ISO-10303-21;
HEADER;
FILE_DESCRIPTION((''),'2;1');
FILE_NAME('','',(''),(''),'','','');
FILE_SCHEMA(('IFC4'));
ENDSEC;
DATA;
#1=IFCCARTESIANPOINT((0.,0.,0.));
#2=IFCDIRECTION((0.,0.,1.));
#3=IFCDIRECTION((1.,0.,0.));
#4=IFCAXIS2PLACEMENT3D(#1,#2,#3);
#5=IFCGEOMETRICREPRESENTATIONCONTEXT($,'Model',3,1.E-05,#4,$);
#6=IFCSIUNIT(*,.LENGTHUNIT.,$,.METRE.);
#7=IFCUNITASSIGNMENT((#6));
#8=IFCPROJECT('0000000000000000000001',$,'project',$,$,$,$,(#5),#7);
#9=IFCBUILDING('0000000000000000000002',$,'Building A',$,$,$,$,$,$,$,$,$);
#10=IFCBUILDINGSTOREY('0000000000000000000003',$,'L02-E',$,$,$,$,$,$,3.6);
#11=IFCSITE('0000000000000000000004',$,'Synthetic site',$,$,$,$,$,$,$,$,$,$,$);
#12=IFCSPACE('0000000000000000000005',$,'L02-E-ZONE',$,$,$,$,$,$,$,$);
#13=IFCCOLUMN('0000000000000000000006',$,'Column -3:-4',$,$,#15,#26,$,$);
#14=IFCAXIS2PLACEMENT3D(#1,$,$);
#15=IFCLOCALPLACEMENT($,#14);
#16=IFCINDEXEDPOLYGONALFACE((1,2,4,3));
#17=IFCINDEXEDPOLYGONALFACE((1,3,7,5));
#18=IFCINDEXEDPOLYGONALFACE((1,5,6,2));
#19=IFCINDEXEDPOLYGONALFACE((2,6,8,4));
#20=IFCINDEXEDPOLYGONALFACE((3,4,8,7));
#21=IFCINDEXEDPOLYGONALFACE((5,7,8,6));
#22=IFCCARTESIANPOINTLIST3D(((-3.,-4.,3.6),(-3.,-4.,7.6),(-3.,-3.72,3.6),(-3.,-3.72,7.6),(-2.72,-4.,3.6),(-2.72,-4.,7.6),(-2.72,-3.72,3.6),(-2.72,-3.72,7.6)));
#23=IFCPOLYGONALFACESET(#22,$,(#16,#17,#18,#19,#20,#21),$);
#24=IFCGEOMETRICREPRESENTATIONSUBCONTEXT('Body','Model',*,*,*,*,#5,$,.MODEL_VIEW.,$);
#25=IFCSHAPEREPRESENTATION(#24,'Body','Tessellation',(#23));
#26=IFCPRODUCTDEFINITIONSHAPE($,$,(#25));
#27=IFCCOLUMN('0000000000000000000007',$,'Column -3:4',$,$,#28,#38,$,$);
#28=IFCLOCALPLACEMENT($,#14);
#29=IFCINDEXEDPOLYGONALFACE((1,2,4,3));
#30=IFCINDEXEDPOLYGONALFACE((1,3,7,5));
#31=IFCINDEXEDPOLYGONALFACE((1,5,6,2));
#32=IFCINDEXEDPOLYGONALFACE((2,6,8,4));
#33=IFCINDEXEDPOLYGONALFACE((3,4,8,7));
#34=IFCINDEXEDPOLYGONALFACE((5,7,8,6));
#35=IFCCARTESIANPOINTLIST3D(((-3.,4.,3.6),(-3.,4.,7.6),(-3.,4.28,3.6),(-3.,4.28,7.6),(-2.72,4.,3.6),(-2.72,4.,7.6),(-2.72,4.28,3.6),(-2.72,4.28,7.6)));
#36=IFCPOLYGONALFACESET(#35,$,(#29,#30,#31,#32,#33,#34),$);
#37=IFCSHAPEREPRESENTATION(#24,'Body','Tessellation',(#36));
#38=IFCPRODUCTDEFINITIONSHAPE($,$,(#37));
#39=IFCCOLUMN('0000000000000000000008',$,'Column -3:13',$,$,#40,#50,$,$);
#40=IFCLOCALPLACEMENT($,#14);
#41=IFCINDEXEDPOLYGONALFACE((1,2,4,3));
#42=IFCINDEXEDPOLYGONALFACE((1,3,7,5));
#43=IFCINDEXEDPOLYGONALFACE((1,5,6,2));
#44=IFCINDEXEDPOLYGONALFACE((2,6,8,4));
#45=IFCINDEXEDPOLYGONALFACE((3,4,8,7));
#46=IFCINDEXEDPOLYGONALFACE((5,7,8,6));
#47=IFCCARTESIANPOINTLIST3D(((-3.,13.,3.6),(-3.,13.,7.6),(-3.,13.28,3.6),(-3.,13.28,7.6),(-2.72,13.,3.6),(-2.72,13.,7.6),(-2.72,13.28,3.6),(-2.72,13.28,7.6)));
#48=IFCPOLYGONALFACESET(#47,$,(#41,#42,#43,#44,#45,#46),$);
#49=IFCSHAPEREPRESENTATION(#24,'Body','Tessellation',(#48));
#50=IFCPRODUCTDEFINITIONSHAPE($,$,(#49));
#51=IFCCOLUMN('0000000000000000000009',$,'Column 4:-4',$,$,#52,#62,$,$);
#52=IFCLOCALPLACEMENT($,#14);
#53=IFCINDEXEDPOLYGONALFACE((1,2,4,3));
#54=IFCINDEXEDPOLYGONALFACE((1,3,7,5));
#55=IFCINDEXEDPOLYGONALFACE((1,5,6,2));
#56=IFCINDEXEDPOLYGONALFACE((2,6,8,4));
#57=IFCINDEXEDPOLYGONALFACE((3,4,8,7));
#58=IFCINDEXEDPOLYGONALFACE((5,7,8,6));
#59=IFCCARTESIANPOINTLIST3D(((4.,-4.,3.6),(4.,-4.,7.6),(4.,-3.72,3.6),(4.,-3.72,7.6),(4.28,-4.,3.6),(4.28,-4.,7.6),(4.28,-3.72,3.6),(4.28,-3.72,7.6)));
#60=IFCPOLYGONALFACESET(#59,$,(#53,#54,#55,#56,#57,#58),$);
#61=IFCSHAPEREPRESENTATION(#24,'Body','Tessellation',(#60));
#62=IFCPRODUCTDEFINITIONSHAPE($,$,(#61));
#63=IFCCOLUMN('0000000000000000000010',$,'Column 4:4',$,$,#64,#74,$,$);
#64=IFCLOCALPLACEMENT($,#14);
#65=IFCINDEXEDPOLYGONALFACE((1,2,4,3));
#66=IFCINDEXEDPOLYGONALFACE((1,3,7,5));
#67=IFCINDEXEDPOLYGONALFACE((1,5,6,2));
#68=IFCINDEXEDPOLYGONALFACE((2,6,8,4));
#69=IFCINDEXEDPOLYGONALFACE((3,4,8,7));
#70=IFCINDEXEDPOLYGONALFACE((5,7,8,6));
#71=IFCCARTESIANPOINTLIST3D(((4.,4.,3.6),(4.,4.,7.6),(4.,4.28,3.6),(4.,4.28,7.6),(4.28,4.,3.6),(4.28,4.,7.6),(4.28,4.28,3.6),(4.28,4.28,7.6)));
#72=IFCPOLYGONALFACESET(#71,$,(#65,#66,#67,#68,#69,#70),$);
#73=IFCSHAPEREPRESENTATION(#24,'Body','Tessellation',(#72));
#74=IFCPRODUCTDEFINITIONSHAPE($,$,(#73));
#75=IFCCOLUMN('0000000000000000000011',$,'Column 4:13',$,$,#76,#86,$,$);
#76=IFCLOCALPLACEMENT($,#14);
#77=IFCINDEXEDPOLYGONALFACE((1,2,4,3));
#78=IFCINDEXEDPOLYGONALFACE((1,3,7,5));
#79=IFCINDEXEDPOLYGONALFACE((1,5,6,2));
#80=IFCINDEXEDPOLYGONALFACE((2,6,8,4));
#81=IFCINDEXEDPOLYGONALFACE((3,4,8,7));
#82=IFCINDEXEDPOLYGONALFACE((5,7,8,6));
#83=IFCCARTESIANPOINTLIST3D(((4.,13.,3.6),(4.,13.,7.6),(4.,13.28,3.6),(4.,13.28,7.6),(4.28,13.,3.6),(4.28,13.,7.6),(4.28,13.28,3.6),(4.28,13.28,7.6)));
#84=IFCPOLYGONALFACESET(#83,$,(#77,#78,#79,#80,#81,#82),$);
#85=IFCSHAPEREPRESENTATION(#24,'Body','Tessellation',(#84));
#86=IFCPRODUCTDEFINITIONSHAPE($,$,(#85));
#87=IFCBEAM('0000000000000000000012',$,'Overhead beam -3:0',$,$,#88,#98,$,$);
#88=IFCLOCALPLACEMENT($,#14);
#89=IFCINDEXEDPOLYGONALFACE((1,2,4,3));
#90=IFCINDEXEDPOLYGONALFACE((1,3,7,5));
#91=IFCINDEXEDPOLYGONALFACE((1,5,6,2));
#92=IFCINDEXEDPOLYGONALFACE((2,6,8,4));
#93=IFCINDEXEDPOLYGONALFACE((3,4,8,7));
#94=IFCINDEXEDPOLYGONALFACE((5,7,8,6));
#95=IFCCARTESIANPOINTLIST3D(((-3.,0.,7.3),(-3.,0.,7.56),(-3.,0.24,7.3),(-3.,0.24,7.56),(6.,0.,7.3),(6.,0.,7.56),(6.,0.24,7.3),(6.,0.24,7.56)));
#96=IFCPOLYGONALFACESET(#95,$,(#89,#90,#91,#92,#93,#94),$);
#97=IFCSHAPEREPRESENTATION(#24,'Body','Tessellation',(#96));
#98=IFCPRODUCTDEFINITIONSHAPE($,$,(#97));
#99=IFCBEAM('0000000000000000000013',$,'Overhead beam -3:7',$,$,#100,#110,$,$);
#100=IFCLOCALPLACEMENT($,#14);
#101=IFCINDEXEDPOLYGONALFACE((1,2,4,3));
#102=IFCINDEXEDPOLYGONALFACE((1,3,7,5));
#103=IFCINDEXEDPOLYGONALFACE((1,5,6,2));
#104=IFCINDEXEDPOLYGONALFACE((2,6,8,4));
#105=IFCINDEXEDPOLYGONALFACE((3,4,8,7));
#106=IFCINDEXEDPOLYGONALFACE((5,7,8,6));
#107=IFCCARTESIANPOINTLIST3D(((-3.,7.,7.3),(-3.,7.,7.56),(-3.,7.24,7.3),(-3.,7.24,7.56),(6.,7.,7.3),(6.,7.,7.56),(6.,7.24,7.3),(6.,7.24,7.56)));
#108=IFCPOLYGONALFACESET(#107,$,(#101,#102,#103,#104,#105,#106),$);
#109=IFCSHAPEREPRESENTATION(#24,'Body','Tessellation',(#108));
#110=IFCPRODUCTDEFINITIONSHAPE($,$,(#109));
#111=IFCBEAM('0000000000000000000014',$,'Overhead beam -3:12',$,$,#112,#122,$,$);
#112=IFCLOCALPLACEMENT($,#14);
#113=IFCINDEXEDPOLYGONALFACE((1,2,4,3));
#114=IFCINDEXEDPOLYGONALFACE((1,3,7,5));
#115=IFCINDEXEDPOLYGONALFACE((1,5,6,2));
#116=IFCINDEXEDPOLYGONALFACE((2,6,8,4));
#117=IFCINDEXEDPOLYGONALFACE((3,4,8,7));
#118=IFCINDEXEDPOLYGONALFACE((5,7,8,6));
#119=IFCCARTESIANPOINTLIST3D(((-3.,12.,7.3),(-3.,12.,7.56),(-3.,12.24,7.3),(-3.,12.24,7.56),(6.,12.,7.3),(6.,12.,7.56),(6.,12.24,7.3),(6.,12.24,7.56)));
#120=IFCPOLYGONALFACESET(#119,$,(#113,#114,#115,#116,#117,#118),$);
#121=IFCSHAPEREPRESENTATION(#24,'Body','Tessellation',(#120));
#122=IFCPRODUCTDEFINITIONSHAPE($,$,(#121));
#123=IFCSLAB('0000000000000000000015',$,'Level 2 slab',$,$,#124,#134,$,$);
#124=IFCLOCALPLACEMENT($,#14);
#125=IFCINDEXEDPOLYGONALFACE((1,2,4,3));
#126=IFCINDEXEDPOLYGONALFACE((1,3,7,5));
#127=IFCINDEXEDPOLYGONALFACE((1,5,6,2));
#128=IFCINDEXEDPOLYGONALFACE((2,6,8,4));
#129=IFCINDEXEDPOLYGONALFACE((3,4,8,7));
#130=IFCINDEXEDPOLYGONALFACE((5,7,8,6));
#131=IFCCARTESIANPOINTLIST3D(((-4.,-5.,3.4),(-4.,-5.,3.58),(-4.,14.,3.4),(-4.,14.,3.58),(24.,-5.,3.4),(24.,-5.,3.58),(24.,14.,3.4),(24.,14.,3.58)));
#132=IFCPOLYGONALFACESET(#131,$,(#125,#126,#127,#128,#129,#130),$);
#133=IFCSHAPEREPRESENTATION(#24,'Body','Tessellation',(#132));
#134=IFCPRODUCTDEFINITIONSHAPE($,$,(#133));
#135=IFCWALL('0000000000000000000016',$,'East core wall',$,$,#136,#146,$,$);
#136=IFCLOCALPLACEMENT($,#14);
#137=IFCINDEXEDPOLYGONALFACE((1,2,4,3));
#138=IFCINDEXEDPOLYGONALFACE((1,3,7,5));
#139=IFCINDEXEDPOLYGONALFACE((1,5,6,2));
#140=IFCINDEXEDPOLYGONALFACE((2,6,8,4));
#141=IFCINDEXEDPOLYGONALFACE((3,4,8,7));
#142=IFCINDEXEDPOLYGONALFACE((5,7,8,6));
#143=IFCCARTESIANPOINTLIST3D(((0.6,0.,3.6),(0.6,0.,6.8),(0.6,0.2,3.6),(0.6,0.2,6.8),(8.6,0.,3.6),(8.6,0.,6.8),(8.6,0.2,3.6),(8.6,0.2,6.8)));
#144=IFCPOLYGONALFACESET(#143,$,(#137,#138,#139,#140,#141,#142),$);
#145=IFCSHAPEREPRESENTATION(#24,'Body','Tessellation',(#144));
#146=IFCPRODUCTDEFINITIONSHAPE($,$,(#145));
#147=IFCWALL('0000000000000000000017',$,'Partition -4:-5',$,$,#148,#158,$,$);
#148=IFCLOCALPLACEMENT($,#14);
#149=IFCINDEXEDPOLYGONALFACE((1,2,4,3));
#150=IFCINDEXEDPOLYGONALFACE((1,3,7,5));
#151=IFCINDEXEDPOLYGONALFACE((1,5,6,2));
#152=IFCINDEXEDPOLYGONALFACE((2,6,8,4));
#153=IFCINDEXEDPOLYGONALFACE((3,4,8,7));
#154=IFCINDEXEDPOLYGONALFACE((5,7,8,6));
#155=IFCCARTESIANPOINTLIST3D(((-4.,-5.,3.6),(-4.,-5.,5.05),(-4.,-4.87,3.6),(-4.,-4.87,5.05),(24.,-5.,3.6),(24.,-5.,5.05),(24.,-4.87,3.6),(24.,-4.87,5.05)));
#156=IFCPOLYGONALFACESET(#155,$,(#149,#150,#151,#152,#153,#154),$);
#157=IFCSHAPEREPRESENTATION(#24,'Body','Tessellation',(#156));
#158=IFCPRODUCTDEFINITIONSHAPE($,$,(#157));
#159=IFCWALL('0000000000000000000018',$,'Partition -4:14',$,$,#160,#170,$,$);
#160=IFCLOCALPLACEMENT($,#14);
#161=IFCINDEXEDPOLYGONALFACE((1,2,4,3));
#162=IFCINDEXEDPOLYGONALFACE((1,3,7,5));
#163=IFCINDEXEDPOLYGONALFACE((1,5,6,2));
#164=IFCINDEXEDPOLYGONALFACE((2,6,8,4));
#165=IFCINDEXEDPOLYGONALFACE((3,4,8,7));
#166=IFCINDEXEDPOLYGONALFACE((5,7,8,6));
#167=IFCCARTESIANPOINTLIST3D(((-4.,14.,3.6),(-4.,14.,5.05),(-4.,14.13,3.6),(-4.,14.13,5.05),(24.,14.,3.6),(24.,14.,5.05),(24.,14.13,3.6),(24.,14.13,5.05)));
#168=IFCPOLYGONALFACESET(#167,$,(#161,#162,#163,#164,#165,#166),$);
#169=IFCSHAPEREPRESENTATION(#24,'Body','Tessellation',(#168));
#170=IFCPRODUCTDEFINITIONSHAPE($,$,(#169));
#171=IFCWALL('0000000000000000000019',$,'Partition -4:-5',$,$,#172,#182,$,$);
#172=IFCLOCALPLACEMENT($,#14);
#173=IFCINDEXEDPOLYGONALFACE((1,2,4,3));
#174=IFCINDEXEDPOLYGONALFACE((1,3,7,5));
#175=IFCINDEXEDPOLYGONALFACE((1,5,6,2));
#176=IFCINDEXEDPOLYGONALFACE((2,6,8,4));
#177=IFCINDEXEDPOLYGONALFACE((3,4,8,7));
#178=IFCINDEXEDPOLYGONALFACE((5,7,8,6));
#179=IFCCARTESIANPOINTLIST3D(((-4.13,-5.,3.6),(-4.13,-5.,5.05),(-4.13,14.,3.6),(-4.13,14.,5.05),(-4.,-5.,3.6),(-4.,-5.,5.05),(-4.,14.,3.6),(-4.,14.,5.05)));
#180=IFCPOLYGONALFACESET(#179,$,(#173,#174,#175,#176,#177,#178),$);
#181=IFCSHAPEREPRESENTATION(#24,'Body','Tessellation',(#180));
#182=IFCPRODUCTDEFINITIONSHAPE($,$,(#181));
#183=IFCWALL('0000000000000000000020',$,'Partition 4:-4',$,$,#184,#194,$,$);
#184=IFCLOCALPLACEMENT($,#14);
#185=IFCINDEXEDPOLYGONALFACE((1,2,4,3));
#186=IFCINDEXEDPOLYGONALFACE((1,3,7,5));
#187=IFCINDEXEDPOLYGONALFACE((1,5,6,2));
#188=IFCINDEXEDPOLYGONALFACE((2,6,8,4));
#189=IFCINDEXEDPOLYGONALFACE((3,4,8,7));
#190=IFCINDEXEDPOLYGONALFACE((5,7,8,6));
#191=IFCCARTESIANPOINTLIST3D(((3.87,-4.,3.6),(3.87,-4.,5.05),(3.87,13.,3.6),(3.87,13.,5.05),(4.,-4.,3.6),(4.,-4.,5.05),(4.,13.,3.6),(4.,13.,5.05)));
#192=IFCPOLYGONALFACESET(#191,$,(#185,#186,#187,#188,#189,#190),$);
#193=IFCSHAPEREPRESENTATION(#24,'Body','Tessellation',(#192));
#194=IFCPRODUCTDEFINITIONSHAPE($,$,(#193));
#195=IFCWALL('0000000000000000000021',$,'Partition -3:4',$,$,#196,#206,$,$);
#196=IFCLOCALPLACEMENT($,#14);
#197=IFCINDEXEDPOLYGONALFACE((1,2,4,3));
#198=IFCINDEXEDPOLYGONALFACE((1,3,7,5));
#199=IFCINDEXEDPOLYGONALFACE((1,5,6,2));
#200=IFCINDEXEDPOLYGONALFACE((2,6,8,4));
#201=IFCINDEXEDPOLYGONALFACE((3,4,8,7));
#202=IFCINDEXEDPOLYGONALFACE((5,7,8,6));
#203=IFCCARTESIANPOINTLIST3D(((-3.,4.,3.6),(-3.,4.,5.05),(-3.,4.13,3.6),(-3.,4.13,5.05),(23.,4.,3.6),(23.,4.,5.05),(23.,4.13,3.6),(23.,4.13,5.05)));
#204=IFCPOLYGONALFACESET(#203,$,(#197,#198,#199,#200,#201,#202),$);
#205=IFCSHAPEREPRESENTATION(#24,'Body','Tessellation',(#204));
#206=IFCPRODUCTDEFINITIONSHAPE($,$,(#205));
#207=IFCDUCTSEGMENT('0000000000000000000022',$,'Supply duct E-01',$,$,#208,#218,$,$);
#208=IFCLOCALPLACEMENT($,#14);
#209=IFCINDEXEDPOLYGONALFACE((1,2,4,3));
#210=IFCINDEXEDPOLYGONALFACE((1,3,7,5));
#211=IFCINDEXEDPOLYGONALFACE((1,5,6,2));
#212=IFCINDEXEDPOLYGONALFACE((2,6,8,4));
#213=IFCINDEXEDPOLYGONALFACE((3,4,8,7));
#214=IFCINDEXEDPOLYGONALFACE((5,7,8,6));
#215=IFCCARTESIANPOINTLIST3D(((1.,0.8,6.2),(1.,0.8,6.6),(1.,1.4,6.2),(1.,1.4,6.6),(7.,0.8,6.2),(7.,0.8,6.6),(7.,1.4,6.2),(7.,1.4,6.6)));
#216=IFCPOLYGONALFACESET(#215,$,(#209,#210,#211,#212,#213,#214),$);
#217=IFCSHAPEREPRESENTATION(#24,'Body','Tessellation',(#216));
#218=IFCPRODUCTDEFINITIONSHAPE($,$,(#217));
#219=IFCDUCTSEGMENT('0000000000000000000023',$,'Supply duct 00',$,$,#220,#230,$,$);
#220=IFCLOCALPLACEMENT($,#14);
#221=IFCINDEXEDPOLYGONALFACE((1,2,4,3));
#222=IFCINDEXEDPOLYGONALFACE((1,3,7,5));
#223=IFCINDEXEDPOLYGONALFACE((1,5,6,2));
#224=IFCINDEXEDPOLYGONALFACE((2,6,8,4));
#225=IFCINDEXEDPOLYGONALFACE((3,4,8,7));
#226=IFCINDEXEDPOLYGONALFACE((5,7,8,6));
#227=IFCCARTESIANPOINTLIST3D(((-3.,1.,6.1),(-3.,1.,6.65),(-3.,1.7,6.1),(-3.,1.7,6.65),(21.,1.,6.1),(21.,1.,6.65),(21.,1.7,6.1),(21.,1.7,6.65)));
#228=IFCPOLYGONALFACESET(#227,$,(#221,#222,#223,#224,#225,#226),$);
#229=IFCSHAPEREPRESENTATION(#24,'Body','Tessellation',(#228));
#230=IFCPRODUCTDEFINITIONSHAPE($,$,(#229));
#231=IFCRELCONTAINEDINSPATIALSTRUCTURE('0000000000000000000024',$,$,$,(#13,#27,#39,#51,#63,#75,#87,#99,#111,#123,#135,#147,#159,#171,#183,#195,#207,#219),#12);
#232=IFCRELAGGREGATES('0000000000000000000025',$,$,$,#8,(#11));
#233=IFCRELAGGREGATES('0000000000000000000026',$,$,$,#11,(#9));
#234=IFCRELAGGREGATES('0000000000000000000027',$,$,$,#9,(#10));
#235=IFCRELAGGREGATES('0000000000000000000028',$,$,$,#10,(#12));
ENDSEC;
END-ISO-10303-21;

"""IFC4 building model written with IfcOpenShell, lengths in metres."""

from ifc_helpers import new_model, si_unit, frame, origin_with_axes, place, context, subcontext, project, spatial, indexed_curve, outline, extrude, element, save


model = new_model("IFC4")

# Units and contexts
model_context = context("Model", 3, precision=1e-05, world=origin_with_axes())
body_context = subcontext(model_context, "Body", "Model", "MODEL_VIEW")
ifc_project = project(units=[si_unit("LENGTHUNIT", "METRE")], contexts=[model_context])

# Site, building, storey, space
site = spatial("IfcSite", under=ifc_project, Name="Synthetic site")
building = spatial("IfcBuilding", under=site, Name="Building A")
storey = spatial("IfcBuildingStorey", under=building, Name="L02-E", Elevation=3.6)
space = spatial("IfcSpace", under=storey, Name="L02-E-ZONE")

# Columns
for number, where, z_axis, x_axis, name in (
    (1, (-3.0, -4.0, 3.6), (0.0, 0.0, 1.0), (1.0, 0.0, 0.0), "Column -3:-4"),
    (2, (-3.0, 4.0, 3.6), (0.0, 0.0, 1.0), (1.0, 0.0, 0.0), "Column -3:4"),
    (3, (-3.0, 13.0, 3.6), (0.0, 0.0, 1.0), (1.0, 0.0, 0.0), "Column -3:13"),
    (4, (4.0, -4.0, 3.6), (0.0, 0.0, 1.0), (1.0, 0.0, 0.0), "Column 4:-4"),
    (5, (4.0, 4.0, 3.6), (0.0, 0.0, 1.0), (1.0, 0.0, 0.0), "Column 4:4"),
    (6, (4.0, 13.0, 3.6), (0.0, 0.0, 1.0), (1.0, 0.0, 0.0), "Column 4:13"),
):
    element("IfcColumn", number, at=place(None, frame(where, z_axis=z_axis, x_axis=x_axis)), inside=space, Name=name, context=body_context, shape_type="SweptSolid", body=[
        extrude(outline(indexed_curve([(0.0, 0.0), (0.0, 0.28), (0.28, 0.28), (0.28, 0.0), (0.0, 0.0)], self_intersect=False)), origin_with_axes(), (0.0, 0.0, 1.0), 4.0),
    ])

# Beams
for number, where, z_axis, x_axis, name in (
    (7, (-3.0, 0.0, 7.3), (0.0, 0.0, 1.0), (1.0, 0.0, 0.0), "Overhead beam -3:0"),
    (8, (-3.0, 7.0, 7.3), (0.0, 0.0, 1.0), (1.0, 0.0, 0.0), "Overhead beam -3:7"),
    (9, (-3.0, 12.0, 7.3), (0.0, 0.0, 1.0), (1.0, 0.0, 0.0), "Overhead beam -3:12"),
):
    element("IfcBeam", number, at=place(None, frame(where, z_axis=z_axis, x_axis=x_axis)), inside=space, Name=name, context=body_context, shape_type="SweptSolid", body=[
        extrude(outline(indexed_curve([(0.0, 0.0), (0.0, 0.24), (9.0, 0.24), (9.0, 0.0), (0.0, 0.0)], self_intersect=False)), origin_with_axes(), (0.0, 0.0, 1.0), 0.26),
    ])

# Slab
slab_placement = place(None, frame((-4.0, -5.0, 3.4), z_axis=(0.0, 0.0, 1.0), x_axis=(1.0, 0.0, 0.0)))
element("IfcSlab", 10, at=slab_placement, inside=space, Name="Level 2 slab", context=body_context, shape_type="SweptSolid", body=[
    extrude(outline(indexed_curve([(0.0, 0.0), (0.0, 19.0), (28.0, 19.0), (28.0, 0.0), (0.0, 0.0)], self_intersect=False)), origin_with_axes(), (0.0, 0.0, 1.0), 0.18),
])

# Walls
wall_1_placement = place(None, frame((0.6, 0.0, 3.6), z_axis=(0.0, 0.0, 1.0), x_axis=(1.0, 0.0, 0.0)))
element("IfcWall", 11, at=wall_1_placement, inside=space, Name="East core wall", context=body_context, shape_type="SweptSolid", body=[
    extrude(outline(indexed_curve([(0.0, 0.0), (0.0, 0.2), (8.0, 0.2), (8.0, 0.0), (0.0, 0.0)], self_intersect=False)), origin_with_axes(), (0.0, 0.0, 1.0), 3.2),
])
for number, where, z_axis, x_axis, name in (
    (12, (-4.0, -5.0, 3.6), (0.0, 0.0, 1.0), (1.0, 0.0, 0.0), "Partition -4:-5"),
    (13, (-4.0, 14.0, 3.6), (0.0, 0.0, 1.0), (1.0, 0.0, 0.0), "Partition -4:14"),
):
    element("IfcWall", number, at=place(None, frame(where, z_axis=z_axis, x_axis=x_axis)), inside=space, Name=name, context=body_context, shape_type="SweptSolid", body=[
        extrude(outline(indexed_curve([(0.0, 0.0), (0.0, 0.13), (28.0, 0.13), (28.0, 0.0), (0.0, 0.0)], self_intersect=False)), origin_with_axes(), (0.0, 0.0, 1.0), 1.45),
    ])
wall_2_placement = place(None, frame((-4.0, -5.0, 3.6), z_axis=(0.0, 0.0, 1.0), x_axis=(0.0, 1.0, 0.0)))
element("IfcWall", 14, at=wall_2_placement, inside=space, Name="Partition -4:-5", context=body_context, shape_type="SweptSolid", body=[
    extrude(outline(indexed_curve([(0.0, 0.0), (0.0, 0.13), (19.0, 0.13), (19.0, 0.0), (0.0, 0.0)], self_intersect=False)), origin_with_axes(), (0.0, 0.0, 1.0), 1.45),
])
wall_3_placement = place(None, frame((4.0, -4.0, 3.6), z_axis=(0.0, 0.0, 1.0), x_axis=(0.0, 1.0, 0.0)))
element("IfcWall", 15, at=wall_3_placement, inside=space, Name="Partition 4:-4", context=body_context, shape_type="SweptSolid", body=[
    extrude(outline(indexed_curve([(0.0, 0.0), (0.0, 0.13), (17.0, 0.13), (17.0, 0.0), (0.0, 0.0)], self_intersect=False)), origin_with_axes(), (0.0, 0.0, 1.0), 1.45),
])
wall_4_placement = place(None, frame((-3.0, 4.0, 3.6), z_axis=(0.0, 0.0, 1.0), x_axis=(1.0, 0.0, 0.0)))
element("IfcWall", 16, at=wall_4_placement, inside=space, Name="Partition -3:4", context=body_context, shape_type="SweptSolid", body=[
    extrude(outline(indexed_curve([(0.0, 0.0), (0.0, 0.13), (26.0, 0.13), (26.0, 0.0), (0.0, 0.0)], self_intersect=False)), origin_with_axes(), (0.0, 0.0, 1.0), 1.45),
])

# Duct segments
duct_segment_1_placement = place(None, frame((1.0, 0.8, 6.2), z_axis=(0.0, 0.0, 1.0), x_axis=(1.0, 0.0, 0.0)))
element("IfcDuctSegment", 17, at=duct_segment_1_placement, inside=space, Name="Supply duct E-01", context=body_context, shape_type="SweptSolid", body=[
    extrude(outline(indexed_curve([(0.0, 0.0), (0.0, 0.6), (6.0, 0.6), (6.0, 0.0), (0.0, 0.0)], self_intersect=False)), origin_with_axes(), (0.0, 0.0, 1.0), 0.4),
])
duct_segment_2_placement = place(None, frame((-3.0, 1.0, 6.1), z_axis=(0.0, 0.0, 1.0), x_axis=(1.0, 0.0, 0.0)))
element("IfcDuctSegment", 18, at=duct_segment_2_placement, inside=space, Name="Supply duct 00", context=body_context, shape_type="SweptSolid", body=[
    extrude(outline(indexed_curve([(0.0, 0.0), (0.0, 0.7), (24.0, 0.7), (24.0, 0.0), (0.0, 0.0)], self_intersect=False)), origin_with_axes(), (0.0, 0.0, 1.0), 0.55),
])

save(model, "model.ifc")
